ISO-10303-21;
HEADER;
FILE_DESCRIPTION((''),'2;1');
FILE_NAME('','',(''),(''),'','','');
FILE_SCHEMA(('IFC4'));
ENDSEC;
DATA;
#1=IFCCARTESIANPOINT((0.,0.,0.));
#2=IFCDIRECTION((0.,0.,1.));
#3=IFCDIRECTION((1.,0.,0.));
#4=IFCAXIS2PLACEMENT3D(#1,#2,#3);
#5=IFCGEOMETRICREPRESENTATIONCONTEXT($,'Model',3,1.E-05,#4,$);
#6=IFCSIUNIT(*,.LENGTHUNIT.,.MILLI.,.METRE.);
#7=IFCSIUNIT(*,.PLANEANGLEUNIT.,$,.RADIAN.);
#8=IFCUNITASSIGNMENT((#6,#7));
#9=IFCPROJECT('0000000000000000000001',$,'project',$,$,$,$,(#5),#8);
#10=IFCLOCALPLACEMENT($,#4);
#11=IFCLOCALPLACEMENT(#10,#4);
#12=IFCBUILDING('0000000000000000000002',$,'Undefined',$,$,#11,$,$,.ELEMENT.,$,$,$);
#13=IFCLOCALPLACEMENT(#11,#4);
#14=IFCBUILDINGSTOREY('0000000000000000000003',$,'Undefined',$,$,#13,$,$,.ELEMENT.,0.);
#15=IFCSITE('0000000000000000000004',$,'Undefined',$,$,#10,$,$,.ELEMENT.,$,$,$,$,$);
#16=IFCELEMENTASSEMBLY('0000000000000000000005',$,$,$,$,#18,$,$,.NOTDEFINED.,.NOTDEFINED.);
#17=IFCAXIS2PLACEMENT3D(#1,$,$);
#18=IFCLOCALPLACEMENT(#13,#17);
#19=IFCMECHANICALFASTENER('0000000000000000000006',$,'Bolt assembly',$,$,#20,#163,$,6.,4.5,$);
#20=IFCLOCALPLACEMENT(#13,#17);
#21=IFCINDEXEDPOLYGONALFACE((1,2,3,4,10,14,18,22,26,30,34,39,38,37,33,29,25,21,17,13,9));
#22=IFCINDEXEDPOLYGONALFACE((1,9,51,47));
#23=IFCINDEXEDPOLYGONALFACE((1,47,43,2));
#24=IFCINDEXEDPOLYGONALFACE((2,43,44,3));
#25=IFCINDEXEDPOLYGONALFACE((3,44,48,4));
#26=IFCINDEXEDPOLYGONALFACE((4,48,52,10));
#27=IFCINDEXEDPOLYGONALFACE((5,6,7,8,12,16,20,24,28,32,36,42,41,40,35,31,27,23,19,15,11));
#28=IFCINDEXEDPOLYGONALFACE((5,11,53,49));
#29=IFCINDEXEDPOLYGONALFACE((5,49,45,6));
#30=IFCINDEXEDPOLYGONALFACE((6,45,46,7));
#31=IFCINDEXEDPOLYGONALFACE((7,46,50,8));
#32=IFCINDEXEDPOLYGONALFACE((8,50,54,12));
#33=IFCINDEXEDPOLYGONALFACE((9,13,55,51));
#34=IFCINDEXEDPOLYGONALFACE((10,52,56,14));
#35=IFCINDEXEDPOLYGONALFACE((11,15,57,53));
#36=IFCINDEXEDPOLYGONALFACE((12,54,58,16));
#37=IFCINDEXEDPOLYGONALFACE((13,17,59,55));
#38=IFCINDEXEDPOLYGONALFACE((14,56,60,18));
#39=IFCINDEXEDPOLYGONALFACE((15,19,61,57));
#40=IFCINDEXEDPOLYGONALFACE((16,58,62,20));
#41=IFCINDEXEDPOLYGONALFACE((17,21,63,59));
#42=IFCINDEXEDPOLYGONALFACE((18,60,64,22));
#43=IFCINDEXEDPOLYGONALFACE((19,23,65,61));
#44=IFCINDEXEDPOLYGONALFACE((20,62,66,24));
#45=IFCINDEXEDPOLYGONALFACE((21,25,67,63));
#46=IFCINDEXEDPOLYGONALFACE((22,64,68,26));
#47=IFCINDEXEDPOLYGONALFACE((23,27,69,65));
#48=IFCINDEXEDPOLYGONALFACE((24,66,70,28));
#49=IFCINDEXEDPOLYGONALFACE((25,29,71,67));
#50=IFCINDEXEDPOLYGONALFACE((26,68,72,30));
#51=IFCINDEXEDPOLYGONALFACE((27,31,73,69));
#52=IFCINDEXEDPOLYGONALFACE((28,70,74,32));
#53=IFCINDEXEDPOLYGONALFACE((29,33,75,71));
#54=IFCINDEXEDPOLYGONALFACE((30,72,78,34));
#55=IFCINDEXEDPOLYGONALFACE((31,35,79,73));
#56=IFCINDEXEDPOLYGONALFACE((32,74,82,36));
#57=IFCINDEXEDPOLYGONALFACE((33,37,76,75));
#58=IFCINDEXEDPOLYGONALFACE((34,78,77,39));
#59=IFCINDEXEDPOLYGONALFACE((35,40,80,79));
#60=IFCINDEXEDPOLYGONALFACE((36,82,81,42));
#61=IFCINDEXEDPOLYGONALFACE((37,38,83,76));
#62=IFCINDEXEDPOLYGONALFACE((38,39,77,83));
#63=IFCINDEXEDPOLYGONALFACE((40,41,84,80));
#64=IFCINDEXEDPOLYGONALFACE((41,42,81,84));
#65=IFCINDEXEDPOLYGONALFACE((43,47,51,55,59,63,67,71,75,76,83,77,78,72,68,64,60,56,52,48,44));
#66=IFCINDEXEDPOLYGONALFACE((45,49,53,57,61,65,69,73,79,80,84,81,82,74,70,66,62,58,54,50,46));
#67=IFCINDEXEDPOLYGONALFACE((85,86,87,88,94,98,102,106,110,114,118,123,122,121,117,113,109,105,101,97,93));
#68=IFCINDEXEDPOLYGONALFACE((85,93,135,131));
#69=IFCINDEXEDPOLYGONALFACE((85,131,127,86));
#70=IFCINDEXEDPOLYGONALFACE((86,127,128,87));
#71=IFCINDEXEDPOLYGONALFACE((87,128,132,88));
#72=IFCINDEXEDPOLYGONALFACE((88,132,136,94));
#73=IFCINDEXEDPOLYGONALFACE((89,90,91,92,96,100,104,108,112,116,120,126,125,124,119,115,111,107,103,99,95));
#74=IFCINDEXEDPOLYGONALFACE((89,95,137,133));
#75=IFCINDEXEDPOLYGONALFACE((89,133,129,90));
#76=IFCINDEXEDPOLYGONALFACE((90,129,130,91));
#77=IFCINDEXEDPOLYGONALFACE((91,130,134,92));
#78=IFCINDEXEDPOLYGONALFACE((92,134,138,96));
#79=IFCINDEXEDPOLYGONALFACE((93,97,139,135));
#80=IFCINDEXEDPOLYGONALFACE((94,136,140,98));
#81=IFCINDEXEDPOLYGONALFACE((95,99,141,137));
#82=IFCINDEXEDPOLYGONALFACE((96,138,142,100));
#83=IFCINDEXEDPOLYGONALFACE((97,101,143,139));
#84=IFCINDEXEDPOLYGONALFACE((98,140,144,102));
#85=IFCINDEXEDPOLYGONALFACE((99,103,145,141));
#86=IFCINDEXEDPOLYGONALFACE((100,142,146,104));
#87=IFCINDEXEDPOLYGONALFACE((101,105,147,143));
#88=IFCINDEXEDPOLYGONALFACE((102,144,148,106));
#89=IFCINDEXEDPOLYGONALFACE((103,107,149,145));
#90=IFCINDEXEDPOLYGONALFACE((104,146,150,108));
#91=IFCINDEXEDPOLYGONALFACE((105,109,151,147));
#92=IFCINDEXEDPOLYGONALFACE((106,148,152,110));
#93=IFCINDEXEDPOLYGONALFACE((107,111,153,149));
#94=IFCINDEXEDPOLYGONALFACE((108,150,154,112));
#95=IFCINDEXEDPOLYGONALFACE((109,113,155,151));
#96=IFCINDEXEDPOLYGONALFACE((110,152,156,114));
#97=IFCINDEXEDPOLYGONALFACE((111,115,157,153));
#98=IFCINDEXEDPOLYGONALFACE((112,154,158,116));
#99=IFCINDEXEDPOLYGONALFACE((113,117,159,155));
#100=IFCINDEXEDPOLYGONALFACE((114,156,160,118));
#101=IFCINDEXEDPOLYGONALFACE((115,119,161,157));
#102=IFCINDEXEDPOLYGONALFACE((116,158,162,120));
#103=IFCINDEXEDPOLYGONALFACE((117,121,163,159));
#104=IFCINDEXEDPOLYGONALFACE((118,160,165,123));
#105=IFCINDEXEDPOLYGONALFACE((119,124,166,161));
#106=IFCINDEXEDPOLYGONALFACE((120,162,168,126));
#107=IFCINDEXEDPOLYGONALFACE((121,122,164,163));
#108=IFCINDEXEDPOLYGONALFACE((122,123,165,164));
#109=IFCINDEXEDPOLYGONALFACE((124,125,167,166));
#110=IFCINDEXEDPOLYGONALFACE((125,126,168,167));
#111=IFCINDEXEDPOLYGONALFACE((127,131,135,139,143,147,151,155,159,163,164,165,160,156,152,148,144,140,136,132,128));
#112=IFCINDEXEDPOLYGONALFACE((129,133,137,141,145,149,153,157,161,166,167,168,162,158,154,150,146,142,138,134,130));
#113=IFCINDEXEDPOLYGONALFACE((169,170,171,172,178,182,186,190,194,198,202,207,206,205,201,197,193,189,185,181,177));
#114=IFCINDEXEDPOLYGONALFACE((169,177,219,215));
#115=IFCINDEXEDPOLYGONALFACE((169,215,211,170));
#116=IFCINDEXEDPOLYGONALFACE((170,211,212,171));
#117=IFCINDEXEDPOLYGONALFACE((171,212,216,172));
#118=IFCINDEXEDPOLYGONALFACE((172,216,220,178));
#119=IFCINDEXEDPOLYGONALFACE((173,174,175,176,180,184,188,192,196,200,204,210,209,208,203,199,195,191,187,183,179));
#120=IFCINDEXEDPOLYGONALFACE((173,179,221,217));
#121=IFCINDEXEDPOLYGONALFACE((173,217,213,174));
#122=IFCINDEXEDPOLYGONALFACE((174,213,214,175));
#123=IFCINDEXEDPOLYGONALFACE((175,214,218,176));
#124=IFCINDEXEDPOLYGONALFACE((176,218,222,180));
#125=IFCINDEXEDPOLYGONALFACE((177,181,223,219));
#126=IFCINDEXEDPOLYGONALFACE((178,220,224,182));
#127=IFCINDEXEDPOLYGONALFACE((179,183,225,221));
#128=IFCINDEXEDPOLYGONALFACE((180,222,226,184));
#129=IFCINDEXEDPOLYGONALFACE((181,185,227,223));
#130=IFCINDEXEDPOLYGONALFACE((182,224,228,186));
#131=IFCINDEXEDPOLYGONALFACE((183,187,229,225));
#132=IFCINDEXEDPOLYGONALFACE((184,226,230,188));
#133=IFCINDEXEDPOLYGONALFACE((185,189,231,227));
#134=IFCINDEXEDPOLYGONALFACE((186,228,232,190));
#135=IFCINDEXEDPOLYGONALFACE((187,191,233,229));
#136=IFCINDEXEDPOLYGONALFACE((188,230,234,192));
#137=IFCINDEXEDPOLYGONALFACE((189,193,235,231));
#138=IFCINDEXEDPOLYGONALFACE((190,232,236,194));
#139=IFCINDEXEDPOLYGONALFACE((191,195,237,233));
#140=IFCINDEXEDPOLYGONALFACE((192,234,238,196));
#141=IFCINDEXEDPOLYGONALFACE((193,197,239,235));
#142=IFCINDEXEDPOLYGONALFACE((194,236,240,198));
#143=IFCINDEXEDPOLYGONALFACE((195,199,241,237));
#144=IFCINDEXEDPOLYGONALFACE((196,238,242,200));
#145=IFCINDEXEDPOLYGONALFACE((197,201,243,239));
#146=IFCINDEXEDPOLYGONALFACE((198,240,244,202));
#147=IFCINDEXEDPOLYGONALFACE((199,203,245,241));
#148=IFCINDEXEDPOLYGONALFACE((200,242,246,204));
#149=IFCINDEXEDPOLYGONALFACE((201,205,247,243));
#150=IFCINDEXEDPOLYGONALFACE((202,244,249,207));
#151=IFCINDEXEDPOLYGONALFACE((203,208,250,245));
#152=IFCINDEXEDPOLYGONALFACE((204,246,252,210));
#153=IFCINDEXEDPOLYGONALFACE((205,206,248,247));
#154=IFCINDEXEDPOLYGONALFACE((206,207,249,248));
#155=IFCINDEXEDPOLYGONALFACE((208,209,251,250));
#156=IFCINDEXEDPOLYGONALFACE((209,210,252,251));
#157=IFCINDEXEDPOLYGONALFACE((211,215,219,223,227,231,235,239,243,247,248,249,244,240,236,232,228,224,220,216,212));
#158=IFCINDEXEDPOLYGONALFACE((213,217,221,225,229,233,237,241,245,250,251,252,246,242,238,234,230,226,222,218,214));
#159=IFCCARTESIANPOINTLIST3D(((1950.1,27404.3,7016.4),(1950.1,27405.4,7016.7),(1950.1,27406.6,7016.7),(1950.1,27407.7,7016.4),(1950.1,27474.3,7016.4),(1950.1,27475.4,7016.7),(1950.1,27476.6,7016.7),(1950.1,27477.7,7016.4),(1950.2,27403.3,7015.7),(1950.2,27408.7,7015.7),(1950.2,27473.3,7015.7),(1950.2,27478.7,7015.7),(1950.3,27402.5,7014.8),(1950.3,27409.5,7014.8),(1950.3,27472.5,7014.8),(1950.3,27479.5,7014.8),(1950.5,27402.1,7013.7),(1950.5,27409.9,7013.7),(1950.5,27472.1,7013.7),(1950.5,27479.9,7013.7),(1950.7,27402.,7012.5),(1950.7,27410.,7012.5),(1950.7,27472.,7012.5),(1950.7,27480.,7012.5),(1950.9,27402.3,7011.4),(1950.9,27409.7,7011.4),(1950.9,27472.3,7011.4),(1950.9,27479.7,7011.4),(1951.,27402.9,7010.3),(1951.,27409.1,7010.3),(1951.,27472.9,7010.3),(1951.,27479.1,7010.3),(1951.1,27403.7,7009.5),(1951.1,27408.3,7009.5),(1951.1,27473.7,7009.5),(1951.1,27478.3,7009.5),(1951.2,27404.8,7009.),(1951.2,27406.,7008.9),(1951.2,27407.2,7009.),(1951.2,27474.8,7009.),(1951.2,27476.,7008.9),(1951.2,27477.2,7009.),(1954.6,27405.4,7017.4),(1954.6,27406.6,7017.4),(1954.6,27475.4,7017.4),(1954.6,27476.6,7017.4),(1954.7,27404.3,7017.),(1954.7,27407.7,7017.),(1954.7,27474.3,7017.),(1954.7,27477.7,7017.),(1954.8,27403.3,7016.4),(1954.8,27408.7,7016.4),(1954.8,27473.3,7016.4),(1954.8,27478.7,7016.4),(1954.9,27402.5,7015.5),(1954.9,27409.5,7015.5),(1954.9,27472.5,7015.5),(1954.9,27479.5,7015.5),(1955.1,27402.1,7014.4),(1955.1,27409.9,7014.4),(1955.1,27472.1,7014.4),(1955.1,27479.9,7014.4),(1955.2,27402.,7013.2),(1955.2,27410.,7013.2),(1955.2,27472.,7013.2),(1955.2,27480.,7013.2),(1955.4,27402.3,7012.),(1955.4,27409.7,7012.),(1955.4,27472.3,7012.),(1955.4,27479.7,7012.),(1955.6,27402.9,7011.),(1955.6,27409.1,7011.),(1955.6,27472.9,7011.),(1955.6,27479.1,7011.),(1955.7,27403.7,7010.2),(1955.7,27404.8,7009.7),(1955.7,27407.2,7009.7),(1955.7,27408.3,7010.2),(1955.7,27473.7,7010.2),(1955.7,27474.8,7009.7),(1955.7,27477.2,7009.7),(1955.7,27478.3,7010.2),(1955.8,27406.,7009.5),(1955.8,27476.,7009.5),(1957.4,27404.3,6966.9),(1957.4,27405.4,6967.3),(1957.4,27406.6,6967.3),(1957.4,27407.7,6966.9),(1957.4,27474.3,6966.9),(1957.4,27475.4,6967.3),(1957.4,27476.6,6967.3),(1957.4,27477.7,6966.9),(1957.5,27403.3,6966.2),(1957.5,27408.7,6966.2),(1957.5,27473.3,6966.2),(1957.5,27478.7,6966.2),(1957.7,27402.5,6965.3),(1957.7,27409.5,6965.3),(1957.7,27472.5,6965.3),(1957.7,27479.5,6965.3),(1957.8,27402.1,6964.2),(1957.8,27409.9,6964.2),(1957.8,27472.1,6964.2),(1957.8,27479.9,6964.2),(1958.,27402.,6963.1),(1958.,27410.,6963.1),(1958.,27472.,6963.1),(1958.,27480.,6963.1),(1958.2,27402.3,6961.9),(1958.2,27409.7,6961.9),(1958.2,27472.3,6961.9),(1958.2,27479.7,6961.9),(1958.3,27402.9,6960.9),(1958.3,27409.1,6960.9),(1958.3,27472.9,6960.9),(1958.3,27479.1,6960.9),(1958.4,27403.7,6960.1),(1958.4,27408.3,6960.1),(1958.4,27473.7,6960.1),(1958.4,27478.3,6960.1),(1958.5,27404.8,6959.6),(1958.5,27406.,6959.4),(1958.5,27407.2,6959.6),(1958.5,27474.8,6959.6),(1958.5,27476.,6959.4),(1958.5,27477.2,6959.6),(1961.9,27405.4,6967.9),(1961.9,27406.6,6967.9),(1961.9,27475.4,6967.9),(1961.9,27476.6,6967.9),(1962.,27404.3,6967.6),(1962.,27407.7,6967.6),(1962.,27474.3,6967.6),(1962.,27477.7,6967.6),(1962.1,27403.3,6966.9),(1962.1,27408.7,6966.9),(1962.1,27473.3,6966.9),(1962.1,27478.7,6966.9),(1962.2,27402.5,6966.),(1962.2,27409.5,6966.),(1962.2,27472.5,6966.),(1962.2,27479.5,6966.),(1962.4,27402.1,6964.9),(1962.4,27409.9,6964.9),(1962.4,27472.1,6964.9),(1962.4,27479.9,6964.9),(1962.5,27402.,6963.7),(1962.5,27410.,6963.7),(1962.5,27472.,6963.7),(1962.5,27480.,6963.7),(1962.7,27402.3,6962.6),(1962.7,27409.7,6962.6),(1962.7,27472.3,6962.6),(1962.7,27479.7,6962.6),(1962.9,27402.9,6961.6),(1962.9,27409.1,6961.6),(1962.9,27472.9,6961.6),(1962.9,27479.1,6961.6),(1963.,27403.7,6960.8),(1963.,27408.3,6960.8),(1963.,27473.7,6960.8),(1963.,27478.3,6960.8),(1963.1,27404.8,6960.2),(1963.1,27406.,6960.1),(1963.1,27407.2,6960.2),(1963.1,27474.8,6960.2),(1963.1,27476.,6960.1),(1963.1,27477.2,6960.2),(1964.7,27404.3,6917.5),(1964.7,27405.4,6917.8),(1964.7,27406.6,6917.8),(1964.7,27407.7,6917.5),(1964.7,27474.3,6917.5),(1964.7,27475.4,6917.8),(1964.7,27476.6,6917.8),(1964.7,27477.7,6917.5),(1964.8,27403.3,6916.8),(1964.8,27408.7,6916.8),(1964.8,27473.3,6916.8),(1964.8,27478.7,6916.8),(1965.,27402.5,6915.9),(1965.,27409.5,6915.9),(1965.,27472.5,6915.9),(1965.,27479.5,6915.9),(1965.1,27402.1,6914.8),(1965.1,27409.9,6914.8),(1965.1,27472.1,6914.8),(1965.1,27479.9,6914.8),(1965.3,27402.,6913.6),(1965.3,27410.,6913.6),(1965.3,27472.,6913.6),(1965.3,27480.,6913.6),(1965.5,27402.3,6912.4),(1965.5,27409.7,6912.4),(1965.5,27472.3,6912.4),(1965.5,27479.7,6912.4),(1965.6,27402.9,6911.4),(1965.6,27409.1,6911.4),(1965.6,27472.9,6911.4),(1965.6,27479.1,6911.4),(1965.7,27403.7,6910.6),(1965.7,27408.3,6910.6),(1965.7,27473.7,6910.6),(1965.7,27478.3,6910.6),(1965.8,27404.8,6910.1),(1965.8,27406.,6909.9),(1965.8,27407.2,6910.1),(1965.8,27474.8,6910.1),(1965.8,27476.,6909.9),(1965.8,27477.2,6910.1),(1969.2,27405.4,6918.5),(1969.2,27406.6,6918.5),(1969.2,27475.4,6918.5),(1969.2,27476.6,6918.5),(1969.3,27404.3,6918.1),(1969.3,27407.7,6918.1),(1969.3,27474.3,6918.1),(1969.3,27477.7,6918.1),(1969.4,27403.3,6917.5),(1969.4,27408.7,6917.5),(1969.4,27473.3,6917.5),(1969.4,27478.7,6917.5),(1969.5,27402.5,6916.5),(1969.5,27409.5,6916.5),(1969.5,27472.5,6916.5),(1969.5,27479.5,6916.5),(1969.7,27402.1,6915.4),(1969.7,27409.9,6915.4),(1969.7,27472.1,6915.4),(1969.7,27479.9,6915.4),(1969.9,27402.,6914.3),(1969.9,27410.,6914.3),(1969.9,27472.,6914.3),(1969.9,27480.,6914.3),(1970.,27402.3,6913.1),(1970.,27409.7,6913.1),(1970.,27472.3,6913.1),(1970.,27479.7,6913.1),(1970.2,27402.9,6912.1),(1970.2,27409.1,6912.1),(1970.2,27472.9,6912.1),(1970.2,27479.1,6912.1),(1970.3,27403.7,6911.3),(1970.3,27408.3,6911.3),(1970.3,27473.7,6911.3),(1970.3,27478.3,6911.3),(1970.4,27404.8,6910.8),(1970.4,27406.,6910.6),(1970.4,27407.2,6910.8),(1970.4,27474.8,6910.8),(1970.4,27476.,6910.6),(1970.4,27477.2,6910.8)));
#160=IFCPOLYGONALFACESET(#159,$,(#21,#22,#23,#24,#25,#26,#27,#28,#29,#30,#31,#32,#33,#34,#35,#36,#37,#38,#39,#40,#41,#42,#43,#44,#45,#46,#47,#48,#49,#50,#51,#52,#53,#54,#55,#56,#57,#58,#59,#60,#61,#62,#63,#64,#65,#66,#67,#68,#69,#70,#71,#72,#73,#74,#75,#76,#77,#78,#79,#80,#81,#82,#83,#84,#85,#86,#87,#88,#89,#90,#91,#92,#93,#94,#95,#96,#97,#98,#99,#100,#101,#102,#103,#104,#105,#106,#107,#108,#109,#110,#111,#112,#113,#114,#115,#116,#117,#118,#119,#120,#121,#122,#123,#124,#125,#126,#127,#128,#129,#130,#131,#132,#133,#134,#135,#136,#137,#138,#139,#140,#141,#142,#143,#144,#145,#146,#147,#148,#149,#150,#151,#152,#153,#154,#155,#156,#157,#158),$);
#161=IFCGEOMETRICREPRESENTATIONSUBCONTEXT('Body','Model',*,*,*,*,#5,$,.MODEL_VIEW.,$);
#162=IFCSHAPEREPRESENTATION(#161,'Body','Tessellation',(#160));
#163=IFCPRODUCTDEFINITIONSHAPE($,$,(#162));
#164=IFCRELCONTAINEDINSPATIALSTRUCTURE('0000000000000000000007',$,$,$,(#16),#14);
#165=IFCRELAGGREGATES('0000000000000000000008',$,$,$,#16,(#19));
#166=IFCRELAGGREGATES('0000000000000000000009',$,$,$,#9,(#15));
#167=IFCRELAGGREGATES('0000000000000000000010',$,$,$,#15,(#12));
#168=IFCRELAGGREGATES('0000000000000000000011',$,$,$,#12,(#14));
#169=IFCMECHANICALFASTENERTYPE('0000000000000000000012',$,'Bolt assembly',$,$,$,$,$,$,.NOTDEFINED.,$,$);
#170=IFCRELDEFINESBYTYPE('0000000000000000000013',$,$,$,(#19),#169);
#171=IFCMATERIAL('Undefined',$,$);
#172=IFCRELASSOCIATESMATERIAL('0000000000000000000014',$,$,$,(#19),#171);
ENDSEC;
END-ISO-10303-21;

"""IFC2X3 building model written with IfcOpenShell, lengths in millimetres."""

from ifc_helpers import new_model, si_unit, frame, origin_with_axes, origin_2d_with_axis, place, context, subcontext, project, spatial, circle, extrude, source, transform, mapped, material, type_object, element, aggregate, save


model = new_model("IFC2X3")

# Units and contexts
model_context = context("Model", 3, precision=1e-05, world=origin_with_axes())
body_context = subcontext(model_context, "Body", "Model", "MODEL_VIEW")
ifc_project = project(units=[si_unit("LENGTHUNIT", "METRE", prefix="MILLI"), si_unit("PLANEANGLEUNIT", "RADIAN")], contexts=[model_context])

# Site, building, storey
site_placement = place(None, origin_with_axes())
site = spatial("IfcSite", under=ifc_project, at=site_placement, Name="Undefined", CompositionType="ELEMENT")
building_placement = place(site_placement, origin_with_axes())
building = spatial("IfcBuilding", under=site, at=building_placement, Name="Undefined", CompositionType="ELEMENT")
storey_placement = place(building_placement, origin_with_axes())
storey = spatial("IfcBuildingStorey", under=building, at=storey_placement, Name="Undefined", CompositionType="ELEMENT", Elevation=0.0)

# Element assembly
assembly_1_placement = place(storey_placement, origin_with_axes())
assembly_1 = element("IfcElementAssembly", 1, at=assembly_1_placement, inside=storey, AssemblyPlace="NOTDEFINED", PredefinedType="NOTDEFINED")

# Mechanical fastener
ifc_material_1 = material(Name="Undefined")
mechanical_fastener_type = type_object("IfcMechanicalFastenerType", Name="Bolt assembly")
shared_shape_1 = source(origin_with_axes(), body_context, "Body", "SweptSolid", [
    extrude(circle(Radius=4.0, at=origin_2d_with_axis()), frame((0.0, 0.0, 0.0), z_axis=(0.0, 1.0, 0.0), x_axis=(1.0, 0.0, 0.0)), (0.0, 0.0, 1.0), 4.6),
])
mechanical_fastener_1_placement = place(assembly_1_placement, frame((1950.6, 27441.0, 7012.8), z_axis=(0.0, -1.0, 0.0), x_axis=(0.146203, 0.0, -0.989255)))
mechanical_fastener_1 = element("IfcMechanicalFastener", 2, at=mechanical_fastener_1_placement, type_object=mechanical_fastener_type, material=ifc_material_1, Name="Bolt assembly", NominalDiameter=6.0, NominalLength=4.5, context=body_context, shape_type="MappedRepresentation", body=[
    mapped(shared_shape_1, transform((0.0, 0.0, -35.0))),
    mapped(shared_shape_1, transform((50.0, 0.0, -35.0))),
    mapped(shared_shape_1, transform((100.0, 0.0, -35.0))),
    mapped(shared_shape_1, transform((0.0, 0.0, 35.0))),
    mapped(shared_shape_1, transform((50.0, 0.0, 35.0))),
    mapped(shared_shape_1, transform((100.0, 0.0, 35.0))),
])

aggregate(assembly_1, [mechanical_fastener_1])

save(model, "model.ifc")
